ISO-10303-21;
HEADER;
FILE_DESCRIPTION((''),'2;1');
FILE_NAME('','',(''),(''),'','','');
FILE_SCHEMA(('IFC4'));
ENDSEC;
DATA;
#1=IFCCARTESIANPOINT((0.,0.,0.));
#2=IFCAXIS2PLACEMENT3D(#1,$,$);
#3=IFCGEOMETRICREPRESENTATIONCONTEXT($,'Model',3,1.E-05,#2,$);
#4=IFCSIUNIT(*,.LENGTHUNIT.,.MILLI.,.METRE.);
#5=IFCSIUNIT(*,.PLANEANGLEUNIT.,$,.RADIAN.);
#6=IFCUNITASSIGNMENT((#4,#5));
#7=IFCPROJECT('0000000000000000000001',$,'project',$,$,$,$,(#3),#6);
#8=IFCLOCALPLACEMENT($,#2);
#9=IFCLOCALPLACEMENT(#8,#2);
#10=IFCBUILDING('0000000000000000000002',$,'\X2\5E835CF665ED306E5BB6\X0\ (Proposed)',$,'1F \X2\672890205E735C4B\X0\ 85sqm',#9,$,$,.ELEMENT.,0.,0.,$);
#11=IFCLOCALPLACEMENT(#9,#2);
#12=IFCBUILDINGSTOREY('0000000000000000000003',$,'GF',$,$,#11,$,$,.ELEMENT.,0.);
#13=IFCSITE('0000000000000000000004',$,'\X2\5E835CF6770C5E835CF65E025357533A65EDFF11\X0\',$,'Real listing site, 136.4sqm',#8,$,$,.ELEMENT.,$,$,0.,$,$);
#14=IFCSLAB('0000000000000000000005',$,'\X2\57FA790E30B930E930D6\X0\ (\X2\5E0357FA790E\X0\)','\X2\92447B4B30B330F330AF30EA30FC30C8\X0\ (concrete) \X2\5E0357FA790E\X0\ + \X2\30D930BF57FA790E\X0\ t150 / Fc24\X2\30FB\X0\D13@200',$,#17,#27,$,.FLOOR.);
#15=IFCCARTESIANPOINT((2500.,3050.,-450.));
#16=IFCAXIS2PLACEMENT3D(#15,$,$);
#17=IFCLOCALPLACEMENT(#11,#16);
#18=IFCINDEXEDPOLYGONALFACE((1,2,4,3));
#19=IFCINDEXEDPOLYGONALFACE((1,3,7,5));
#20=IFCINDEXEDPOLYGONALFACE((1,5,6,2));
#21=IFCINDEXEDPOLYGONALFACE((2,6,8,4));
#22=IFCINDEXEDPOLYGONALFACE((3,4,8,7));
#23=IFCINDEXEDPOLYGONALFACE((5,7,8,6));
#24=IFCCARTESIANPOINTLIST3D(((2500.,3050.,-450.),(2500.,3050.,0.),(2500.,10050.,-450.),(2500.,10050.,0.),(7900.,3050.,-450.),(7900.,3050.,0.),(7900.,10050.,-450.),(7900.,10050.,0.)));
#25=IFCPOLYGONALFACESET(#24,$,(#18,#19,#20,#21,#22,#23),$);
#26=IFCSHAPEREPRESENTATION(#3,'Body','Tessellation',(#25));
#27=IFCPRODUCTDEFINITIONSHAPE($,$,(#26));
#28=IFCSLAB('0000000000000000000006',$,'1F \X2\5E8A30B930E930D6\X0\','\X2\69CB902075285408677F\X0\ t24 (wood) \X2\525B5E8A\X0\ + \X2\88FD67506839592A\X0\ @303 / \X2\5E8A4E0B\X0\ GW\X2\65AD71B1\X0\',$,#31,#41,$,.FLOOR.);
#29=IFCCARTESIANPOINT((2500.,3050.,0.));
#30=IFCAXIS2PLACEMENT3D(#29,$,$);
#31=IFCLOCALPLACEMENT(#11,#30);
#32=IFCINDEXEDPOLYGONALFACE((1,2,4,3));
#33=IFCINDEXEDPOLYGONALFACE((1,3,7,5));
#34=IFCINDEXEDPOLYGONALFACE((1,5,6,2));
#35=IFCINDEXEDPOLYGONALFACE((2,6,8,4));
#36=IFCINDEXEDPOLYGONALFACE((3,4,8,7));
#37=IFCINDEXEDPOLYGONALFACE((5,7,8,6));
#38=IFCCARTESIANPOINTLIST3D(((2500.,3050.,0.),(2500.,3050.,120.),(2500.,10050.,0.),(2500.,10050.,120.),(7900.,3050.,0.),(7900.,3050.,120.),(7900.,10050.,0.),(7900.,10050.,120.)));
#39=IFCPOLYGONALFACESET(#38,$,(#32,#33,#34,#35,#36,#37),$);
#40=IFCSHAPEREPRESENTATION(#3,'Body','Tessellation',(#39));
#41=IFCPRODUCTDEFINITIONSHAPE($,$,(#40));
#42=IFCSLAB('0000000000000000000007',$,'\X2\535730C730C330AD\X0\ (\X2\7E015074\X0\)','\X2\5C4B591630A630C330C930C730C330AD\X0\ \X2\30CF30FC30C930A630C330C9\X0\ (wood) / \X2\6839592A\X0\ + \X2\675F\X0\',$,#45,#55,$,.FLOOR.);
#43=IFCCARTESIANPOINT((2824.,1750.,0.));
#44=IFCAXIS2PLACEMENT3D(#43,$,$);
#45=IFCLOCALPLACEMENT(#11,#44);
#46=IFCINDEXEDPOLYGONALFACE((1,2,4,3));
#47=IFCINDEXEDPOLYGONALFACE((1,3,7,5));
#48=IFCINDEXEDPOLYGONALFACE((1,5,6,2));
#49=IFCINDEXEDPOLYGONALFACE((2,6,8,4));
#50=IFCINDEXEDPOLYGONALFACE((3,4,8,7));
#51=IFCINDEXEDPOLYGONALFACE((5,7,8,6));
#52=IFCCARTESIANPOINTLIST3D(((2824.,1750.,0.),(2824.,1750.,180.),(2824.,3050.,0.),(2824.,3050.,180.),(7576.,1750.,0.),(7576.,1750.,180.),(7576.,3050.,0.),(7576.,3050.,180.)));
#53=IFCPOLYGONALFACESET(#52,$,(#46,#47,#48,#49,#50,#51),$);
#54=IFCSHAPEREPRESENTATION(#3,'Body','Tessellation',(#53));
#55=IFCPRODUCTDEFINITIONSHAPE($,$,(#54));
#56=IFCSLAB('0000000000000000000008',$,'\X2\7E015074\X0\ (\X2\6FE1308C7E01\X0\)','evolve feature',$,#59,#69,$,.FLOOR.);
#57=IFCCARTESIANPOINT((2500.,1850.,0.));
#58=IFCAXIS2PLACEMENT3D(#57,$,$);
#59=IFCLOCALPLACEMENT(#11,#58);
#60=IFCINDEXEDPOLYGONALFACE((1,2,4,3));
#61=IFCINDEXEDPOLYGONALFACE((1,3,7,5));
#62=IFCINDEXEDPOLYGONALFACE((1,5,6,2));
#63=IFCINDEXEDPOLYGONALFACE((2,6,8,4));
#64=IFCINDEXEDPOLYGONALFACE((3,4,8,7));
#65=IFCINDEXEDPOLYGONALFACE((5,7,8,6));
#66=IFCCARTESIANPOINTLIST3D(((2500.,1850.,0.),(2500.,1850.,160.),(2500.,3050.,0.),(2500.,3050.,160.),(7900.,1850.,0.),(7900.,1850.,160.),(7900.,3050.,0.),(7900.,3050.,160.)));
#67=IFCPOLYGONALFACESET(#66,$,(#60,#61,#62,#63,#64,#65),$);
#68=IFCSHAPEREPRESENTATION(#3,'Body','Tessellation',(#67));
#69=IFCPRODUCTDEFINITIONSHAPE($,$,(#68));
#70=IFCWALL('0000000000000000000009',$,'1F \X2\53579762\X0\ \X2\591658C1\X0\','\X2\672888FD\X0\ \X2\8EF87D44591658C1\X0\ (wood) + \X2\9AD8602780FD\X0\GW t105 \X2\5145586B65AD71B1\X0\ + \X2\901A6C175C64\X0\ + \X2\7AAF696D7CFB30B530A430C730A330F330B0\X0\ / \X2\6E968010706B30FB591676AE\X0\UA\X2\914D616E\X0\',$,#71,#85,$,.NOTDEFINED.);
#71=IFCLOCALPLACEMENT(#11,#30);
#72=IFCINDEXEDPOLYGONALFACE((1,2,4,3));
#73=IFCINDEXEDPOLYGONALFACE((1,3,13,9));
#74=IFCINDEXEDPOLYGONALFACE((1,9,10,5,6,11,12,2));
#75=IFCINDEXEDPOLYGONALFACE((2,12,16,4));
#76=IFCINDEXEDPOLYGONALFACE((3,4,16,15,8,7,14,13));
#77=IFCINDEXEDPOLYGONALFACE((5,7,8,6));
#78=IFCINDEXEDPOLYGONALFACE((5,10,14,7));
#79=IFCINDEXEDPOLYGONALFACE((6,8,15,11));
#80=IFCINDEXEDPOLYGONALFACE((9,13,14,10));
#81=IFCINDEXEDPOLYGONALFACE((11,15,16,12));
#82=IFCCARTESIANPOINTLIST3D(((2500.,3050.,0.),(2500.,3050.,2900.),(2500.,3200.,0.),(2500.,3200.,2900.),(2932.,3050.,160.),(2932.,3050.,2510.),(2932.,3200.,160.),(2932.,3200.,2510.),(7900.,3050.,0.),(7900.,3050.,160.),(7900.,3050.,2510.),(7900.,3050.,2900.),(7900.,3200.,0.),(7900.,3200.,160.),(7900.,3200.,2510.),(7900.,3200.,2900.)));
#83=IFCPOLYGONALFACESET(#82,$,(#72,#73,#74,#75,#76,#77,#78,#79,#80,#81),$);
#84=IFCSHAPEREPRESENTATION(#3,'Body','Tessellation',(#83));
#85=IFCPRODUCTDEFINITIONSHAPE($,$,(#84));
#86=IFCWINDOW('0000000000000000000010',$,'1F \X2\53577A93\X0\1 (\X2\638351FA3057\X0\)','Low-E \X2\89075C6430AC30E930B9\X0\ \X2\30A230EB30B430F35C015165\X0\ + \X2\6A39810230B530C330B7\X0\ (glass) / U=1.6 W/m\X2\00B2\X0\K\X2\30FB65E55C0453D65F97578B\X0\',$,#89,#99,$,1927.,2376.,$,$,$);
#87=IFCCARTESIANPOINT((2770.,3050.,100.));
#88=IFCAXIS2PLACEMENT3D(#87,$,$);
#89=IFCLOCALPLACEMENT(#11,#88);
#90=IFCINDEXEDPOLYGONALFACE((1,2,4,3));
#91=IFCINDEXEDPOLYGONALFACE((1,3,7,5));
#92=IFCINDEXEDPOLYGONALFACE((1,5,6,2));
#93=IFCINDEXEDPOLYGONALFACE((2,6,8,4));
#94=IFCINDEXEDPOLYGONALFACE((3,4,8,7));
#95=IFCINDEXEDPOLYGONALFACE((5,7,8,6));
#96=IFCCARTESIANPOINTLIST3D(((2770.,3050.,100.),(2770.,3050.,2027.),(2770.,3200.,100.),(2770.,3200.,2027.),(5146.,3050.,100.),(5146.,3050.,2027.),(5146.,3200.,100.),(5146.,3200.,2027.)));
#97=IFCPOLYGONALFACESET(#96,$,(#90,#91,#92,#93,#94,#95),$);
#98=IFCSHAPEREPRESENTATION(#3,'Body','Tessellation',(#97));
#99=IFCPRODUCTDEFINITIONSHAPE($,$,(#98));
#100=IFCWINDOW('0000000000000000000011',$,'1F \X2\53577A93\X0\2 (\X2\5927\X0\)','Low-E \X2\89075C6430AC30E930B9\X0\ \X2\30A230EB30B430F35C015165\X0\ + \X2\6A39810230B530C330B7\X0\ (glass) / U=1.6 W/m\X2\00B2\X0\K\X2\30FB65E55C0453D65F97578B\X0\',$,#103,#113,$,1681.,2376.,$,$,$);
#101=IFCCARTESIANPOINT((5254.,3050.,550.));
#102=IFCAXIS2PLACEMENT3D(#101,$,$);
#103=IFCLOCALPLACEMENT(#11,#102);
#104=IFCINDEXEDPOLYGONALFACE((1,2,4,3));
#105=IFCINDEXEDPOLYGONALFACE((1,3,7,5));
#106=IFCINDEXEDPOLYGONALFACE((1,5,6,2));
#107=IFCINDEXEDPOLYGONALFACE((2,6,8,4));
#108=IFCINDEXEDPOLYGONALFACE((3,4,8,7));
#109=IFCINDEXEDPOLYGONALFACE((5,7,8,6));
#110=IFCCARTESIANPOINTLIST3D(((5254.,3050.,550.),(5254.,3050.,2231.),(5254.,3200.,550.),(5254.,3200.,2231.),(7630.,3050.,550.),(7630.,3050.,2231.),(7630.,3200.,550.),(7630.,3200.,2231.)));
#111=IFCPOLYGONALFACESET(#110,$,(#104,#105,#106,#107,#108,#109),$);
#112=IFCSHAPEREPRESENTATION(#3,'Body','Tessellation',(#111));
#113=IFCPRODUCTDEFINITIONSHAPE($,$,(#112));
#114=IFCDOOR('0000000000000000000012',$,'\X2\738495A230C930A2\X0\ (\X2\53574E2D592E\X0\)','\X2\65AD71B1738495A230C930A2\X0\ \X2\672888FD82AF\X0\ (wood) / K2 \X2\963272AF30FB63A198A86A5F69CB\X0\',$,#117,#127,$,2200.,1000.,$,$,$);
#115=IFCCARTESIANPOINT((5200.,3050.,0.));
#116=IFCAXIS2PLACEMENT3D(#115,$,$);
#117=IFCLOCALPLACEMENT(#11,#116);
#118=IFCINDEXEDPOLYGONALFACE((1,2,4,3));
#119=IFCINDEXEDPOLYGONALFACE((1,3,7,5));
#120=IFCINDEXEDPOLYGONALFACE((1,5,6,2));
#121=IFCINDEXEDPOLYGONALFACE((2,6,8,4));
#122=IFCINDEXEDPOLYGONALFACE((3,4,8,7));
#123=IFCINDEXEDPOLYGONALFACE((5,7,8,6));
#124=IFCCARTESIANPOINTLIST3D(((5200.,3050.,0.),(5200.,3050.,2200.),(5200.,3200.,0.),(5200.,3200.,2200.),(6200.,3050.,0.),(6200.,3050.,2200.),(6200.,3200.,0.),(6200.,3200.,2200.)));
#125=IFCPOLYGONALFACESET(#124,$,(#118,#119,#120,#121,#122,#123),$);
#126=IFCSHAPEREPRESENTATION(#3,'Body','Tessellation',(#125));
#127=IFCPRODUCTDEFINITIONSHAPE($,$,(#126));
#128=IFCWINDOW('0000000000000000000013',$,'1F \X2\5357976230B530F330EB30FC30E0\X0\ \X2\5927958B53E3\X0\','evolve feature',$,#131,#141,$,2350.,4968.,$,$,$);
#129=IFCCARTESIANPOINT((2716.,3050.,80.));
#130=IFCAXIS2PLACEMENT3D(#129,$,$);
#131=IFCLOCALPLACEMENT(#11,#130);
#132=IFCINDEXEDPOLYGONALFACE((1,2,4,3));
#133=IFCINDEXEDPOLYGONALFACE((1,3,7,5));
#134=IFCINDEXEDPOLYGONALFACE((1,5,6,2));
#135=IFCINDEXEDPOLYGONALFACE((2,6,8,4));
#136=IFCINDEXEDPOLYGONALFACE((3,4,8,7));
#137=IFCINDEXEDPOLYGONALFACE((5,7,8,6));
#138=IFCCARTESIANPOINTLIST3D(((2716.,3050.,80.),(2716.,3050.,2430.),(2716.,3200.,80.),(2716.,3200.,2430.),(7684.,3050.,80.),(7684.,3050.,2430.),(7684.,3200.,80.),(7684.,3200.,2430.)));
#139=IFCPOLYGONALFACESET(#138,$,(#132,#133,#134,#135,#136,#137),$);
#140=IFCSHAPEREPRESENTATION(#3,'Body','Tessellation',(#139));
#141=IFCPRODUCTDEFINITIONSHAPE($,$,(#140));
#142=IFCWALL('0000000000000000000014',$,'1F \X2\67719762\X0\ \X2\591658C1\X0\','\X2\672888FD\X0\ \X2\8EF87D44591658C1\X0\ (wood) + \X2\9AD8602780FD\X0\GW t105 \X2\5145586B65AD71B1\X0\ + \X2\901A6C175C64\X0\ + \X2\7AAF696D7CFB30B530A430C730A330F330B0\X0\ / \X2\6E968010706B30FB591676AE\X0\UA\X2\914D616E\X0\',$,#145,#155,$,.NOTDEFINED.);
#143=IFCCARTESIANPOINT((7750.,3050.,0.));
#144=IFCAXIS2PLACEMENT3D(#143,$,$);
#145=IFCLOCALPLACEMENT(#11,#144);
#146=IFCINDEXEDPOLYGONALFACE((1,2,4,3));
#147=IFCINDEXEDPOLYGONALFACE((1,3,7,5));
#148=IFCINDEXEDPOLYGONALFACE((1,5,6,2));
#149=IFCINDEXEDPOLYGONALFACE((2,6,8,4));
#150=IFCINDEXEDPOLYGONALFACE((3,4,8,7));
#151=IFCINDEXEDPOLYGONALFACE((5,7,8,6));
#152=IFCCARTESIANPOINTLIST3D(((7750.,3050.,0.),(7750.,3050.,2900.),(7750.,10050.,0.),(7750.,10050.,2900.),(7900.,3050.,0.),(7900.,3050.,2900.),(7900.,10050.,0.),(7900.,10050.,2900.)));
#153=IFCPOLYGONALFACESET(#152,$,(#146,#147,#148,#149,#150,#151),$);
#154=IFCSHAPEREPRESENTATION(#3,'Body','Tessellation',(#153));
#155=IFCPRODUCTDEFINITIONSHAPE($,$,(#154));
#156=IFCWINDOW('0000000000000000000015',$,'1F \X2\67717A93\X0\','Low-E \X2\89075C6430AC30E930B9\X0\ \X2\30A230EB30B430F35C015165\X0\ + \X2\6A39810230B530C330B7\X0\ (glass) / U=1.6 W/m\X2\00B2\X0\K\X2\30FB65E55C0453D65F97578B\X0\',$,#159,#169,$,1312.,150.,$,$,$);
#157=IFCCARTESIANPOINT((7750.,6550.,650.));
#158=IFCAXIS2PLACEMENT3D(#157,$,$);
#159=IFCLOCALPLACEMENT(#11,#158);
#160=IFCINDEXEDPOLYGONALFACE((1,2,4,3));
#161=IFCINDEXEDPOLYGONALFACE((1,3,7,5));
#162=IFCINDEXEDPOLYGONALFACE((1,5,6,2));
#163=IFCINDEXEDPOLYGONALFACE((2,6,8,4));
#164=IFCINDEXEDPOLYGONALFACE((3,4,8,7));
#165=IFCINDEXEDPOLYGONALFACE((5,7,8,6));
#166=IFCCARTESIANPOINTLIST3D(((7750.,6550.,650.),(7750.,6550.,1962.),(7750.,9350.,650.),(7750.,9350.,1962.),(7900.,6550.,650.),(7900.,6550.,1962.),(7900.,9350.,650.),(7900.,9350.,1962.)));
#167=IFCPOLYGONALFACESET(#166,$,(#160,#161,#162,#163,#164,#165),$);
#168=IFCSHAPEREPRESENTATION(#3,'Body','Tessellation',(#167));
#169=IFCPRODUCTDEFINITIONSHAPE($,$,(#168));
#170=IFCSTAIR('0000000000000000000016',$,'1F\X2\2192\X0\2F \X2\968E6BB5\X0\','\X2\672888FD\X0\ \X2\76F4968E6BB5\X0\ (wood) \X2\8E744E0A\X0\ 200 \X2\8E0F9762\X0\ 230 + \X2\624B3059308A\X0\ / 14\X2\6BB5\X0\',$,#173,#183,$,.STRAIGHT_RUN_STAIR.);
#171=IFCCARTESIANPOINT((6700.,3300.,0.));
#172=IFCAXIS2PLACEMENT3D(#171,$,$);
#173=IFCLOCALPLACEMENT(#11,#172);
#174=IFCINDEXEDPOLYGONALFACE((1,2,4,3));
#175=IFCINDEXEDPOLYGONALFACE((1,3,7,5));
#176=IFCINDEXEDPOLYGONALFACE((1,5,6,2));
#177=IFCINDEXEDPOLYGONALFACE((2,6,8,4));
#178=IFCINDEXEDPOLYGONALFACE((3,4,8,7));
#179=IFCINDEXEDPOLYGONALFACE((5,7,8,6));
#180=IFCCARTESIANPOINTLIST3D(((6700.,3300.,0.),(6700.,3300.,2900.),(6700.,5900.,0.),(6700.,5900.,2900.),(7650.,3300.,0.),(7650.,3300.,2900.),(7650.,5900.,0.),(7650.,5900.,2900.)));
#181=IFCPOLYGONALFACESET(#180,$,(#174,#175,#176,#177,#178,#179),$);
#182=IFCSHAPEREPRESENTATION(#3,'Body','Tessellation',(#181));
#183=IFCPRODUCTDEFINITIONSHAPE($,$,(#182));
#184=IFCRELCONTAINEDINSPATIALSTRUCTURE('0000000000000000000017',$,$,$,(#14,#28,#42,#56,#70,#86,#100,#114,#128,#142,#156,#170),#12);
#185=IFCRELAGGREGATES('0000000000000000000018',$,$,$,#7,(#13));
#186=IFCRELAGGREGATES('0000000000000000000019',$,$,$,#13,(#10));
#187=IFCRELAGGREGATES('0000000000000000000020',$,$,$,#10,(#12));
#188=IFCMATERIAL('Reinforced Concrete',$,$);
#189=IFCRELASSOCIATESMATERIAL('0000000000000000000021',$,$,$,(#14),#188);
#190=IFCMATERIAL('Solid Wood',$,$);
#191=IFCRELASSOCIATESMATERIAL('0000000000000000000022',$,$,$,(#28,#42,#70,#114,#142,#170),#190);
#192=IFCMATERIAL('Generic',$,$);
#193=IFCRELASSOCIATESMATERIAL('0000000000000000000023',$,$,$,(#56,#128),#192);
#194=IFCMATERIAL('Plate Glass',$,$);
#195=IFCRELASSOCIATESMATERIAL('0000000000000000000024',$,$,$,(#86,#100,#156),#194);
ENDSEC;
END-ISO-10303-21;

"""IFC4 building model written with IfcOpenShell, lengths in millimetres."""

from ifc_helpers import new_model, si_unit, frame, frame_2d, origin, place, context, project, spatial, rectangle, extrude, material, element, fill, save


model = new_model("IFC4")

# Units and contexts
model_context = context("Model", 3, precision=1e-05, world=origin())
ifc_project = project(units=[si_unit("LENGTHUNIT", "METRE", prefix="MILLI"), si_unit("PLANEANGLEUNIT", "RADIAN")], contexts=[model_context])

# Site, building, storey
site_placement = place(None, origin())
site = spatial("IfcSite", under=ifc_project, at=site_placement, Name="広島県広島市南区旭１", ObjectType="Real listing site, 136.4sqm", CompositionType="ELEMENT", RefElevation=0.0)
building_placement = place(site_placement, origin())
building = spatial("IfcBuilding", under=site, at=building_placement, Name="広島旭の家 (Proposed)", ObjectType="1F 木造平屋 85sqm", CompositionType="ELEMENT", ElevationOfRefHeight=0.0, ElevationOfTerrain=0.0)
storey_placement = place(building_placement, origin())
storey = spatial("IfcBuildingStorey", under=building, at=storey_placement, Name="GF", CompositionType="ELEMENT", Elevation=0.0)

# Slabs
ifc_material_1 = material(Name="Reinforced Concrete")
slab_1_placement = place(storey_placement, frame((2500.0, 3050.0, -450.0)))
element("IfcSlab", 1, at=slab_1_placement, inside=storey, material=ifc_material_1, Name="基礎スラブ (布基礎)", Description="鉄筋コンクリート (concrete) 布基礎 + ベタ基礎 t150 / Fc24・D13@200", PredefinedType="FLOOR", context=model_context, shape_type="SweptSolid", body=[
    extrude(rectangle(XDim=5400.0, YDim=7000.0, at=frame_2d((2700.0, 3500.0))), frame((2500.0, 3050.0, -450.0)), (0.0, 0.0, 1.0), 450.0),
])
ifc_material_2 = material(Name="Solid Wood")
slab_2_placement = place(storey_placement, frame((2500.0, 3050.0, 0.0)))
element("IfcSlab", 2, at=slab_2_placement, inside=storey, material=ifc_material_2, Name="1F 床スラブ", Description="構造用合板 t24 (wood) 剛床 + 製材根太 @303 / 床下 GW断熱", PredefinedType="FLOOR", context=model_context, shape_type="SweptSolid", body=[
    extrude(rectangle(XDim=5400.0, YDim=7000.0, at=frame_2d((2700.0, 3500.0))), frame((2500.0, 3050.0, 0.0)), (0.0, 0.0, 1.0), 120.0),
])
slab_3_placement = place(storey_placement, frame((2824.0, 1750.0, 0.0)))
element("IfcSlab", 3, at=slab_3_placement, inside=storey, material=ifc_material_2, Name="南デッキ (縁側)", Description="屋外ウッドデッキ ハードウッド (wood) / 根太 + 束", PredefinedType="FLOOR", context=model_context, shape_type="SweptSolid", body=[
    extrude(rectangle(XDim=4752.0, YDim=1300.0, at=frame_2d((2376.0, 650.0))), frame((2824.0, 1750.0, 0.0)), (0.0, 0.0, 1.0), 180.0),
])
ifc_material_3 = material(Name="Generic")
slab_4_placement = place(storey_placement, frame((2500.0, 1850.0, 0.0)))
element("IfcSlab", 4, at=slab_4_placement, inside=storey, material=ifc_material_3, Name="縁側 (濡れ縁)", Description="evolve feature", PredefinedType="FLOOR", context=model_context, shape_type="SweptSolid", body=[
    extrude(rectangle(XDim=5400.0, YDim=1200.0, at=frame_2d((2700.0, 600.0))), frame((2500.0, 1850.0, 0.0)), (0.0, 0.0, 1.0), 160.0),
])

# Wall, openings, windows, door
wall_1_placement = place(storey_placement, frame((2500.0, 3050.0, 0.0)))
wall_1 = element("IfcWall", 5, at=wall_1_placement, inside=storey, material=ifc_material_2, Name="1F 南面 外壁", Description="木製 軸組外壁 (wood) + 高性能GW t105 充填断熱 + 通気層 + 窯業系サイディング / 準耐火・外皮UA配慮", PredefinedType="NOTDEFINED", context=model_context, shape_type="SweptSolid", body=[
    extrude(rectangle(XDim=5400.0, YDim=150.0, at=frame_2d((2700.0, 75.0))), frame((2500.0, 3050.0, 0.0)), (0.0, 0.0, 1.0), 2900.0),
])
opening_1_placement = place(storey_placement, frame((2770.0, 3050.0, 100.0)))
opening_1 = element("IfcOpeningElement", 6, at=opening_1_placement, cuts=wall_1, PredefinedType="NOTDEFINED", context=model_context, shape_type="SweptSolid", body=[
    extrude(rectangle(XDim=2376.0, YDim=150.0, at=frame_2d((1188.0, 75.0))), frame((2770.0, 3050.0, 100.0)), (0.0, 0.0, 1.0), 1927.0),
])
opening_2_placement = place(storey_placement, frame((5254.0, 3050.0, 550.0)))
opening_2 = element("IfcOpeningElement", 7, at=opening_2_placement, cuts=wall_1, PredefinedType="NOTDEFINED", context=model_context, shape_type="SweptSolid", body=[
    extrude(rectangle(XDim=2376.0, YDim=150.0, at=frame_2d((1188.0, 75.0))), frame((5254.0, 3050.0, 550.0)), (0.0, 0.0, 1.0), 1681.0),
])
opening_3_placement = place(storey_placement, frame((5200.0, 3050.0, 0.0)))
opening_3 = element("IfcOpeningElement", 8, at=opening_3_placement, cuts=wall_1, PredefinedType="NOTDEFINED", context=model_context, shape_type="SweptSolid", body=[
    extrude(rectangle(XDim=1000.0, YDim=150.0, at=frame_2d((500.0, 75.0))), frame((5200.0, 3050.0, 0.0)), (0.0, 0.0, 1.0), 2200.0),
])
opening_4_placement = place(storey_placement, frame((2716.0, 3050.0, 80.0)))
opening_4 = element("IfcOpeningElement", 9, at=opening_4_placement, cuts=wall_1, PredefinedType="NOTDEFINED", context=model_context, shape_type="SweptSolid", body=[
    extrude(rectangle(XDim=4968.0, YDim=150.0, at=frame_2d((2484.0, 75.0))), frame((2716.0, 3050.0, 80.0)), (0.0, 0.0, 1.0), 2350.0),
])
ifc_material_4 = material(Name="Plate Glass")
window_1_placement = place(storey_placement, frame((2770.0, 3050.0, 100.0)))
window_1 = element("IfcWindow", 10, at=window_1_placement, inside=storey, material=ifc_material_4, Name="1F 南窓1 (掃出し)", Description="Low-E 複層ガラス アルゴン封入 + 樹脂サッシ (glass) / U=1.6 W/m²K・日射取得型", OverallHeight=1927.0, OverallWidth=2376.0, context=model_context, shape_type="SweptSolid", body=[
    extrude(rectangle(XDim=2376.0, YDim=150.0, at=frame_2d((1188.0, 75.0))), frame((2770.0, 3050.0, 100.0)), (0.0, 0.0, 1.0), 1927.0),
])
fill(opening_1, window_1)
window_2_placement = place(storey_placement, frame((5254.0, 3050.0, 550.0)))
window_2 = element("IfcWindow", 11, at=window_2_placement, inside=storey, material=ifc_material_4, Name="1F 南窓2 (大)", Description="Low-E 複層ガラス アルゴン封入 + 樹脂サッシ (glass) / U=1.6 W/m²K・日射取得型", OverallHeight=1681.0, OverallWidth=2376.0, context=model_context, shape_type="SweptSolid", body=[
    extrude(rectangle(XDim=2376.0, YDim=150.0, at=frame_2d((1188.0, 75.0))), frame((5254.0, 3050.0, 550.0)), (0.0, 0.0, 1.0), 1681.0),
])
fill(opening_2, window_2)
door_placement = place(storey_placement, frame((5200.0, 3050.0, 0.0)))
door = element("IfcDoor", 12, at=door_placement, inside=storey, material=ifc_material_2, Name="玄関ドア (南中央)", Description="断熱玄関ドア 木製芯 (wood) / K2 防犯・採風機構", OverallHeight=2200.0, OverallWidth=1000.0, context=model_context, shape_type="SweptSolid", body=[
    extrude(rectangle(XDim=1000.0, YDim=150.0, at=frame_2d((500.0, 75.0))), frame((5200.0, 3050.0, 0.0)), (0.0, 0.0, 1.0), 2200.0),
])
fill(opening_3, door)
window_3_placement = place(storey_placement, frame((2716.0, 3050.0, 80.0)))
window_3 = element("IfcWindow", 13, at=window_3_placement, inside=storey, material=ifc_material_3, Name="1F 南面サンルーム 大開口", Description="evolve feature", OverallHeight=2350.0, OverallWidth=4968.0, context=model_context, shape_type="SweptSolid", body=[
    extrude(rectangle(XDim=4968.0, YDim=150.0, at=frame_2d((2484.0, 75.0))), frame((2716.0, 3050.0, 80.0)), (0.0, 0.0, 1.0), 2350.0),
])
fill(opening_4, window_3)

# Wall, opening, window
wall_2_placement = place(storey_placement, frame((7750.0, 3050.0, 0.0)))
wall_2 = element("IfcWall", 14, at=wall_2_placement, inside=storey, material=ifc_material_2, Name="1F 東面 外壁", Description="木製 軸組外壁 (wood) + 高性能GW t105 充填断熱 + 通気層 + 窯業系サイディング / 準耐火・外皮UA配慮", PredefinedType="NOTDEFINED", context=model_context, shape_type="SweptSolid", body=[
    extrude(rectangle(XDim=150.0, YDim=7000.0, at=frame_2d((75.0, 3500.0))), frame((7750.0, 3050.0, 0.0)), (0.0, 0.0, 1.0), 2900.0),
])
opening_5_placement = place(storey_placement, frame((7750.0, 6550.0, 650.0)))
opening_5 = element("IfcOpeningElement", 15, at=opening_5_placement, cuts=wall_2, PredefinedType="NOTDEFINED", context=model_context, shape_type="SweptSolid", body=[
    extrude(rectangle(XDim=150.0, YDim=2800.0, at=frame_2d((75.0, 1400.0))), frame((7750.0, 6550.0, 650.0)), (0.0, 0.0, 1.0), 1312.0),
])
window_4_placement = place(storey_placement, frame((7750.0, 6550.0, 650.0)))
window_4 = element("IfcWindow", 16, at=window_4_placement, inside=storey, material=ifc_material_4, Name="1F 東窓", Description="Low-E 複層ガラス アルゴン封入 + 樹脂サッシ (glass) / U=1.6 W/m²K・日射取得型", OverallHeight=1312.0, OverallWidth=150.0, context=model_context, shape_type="SweptSolid", body=[
    extrude(rectangle(XDim=150.0, YDim=2800.0, at=frame_2d((75.0, 1400.0))), frame((7750.0, 6550.0, 650.0)), (0.0, 0.0, 1.0), 1312.0),
])
fill(opening_5, window_4)

# Stair
stair_placement = place(storey_placement, frame((6700.0, 3300.0, 0.0)))
element("IfcStair", 17, at=stair_placement, inside=storey, material=ifc_material_2, Name="1F→2F 階段", Description="木製 直階段 (wood) 蹴上 200 踏面 230 + 手すり / 14段", PredefinedType="STRAIGHT_RUN_STAIR", context=model_context, shape_type="SweptSolid", body=[
    extrude(rectangle(XDim=950.0, YDim=2600.0, at=frame_2d((475.0, 1300.0))), frame((6700.0, 3300.0, 0.0)), (0.0, 0.0, 1.0), 2900.0),
])

save(model, "model.ifc")
